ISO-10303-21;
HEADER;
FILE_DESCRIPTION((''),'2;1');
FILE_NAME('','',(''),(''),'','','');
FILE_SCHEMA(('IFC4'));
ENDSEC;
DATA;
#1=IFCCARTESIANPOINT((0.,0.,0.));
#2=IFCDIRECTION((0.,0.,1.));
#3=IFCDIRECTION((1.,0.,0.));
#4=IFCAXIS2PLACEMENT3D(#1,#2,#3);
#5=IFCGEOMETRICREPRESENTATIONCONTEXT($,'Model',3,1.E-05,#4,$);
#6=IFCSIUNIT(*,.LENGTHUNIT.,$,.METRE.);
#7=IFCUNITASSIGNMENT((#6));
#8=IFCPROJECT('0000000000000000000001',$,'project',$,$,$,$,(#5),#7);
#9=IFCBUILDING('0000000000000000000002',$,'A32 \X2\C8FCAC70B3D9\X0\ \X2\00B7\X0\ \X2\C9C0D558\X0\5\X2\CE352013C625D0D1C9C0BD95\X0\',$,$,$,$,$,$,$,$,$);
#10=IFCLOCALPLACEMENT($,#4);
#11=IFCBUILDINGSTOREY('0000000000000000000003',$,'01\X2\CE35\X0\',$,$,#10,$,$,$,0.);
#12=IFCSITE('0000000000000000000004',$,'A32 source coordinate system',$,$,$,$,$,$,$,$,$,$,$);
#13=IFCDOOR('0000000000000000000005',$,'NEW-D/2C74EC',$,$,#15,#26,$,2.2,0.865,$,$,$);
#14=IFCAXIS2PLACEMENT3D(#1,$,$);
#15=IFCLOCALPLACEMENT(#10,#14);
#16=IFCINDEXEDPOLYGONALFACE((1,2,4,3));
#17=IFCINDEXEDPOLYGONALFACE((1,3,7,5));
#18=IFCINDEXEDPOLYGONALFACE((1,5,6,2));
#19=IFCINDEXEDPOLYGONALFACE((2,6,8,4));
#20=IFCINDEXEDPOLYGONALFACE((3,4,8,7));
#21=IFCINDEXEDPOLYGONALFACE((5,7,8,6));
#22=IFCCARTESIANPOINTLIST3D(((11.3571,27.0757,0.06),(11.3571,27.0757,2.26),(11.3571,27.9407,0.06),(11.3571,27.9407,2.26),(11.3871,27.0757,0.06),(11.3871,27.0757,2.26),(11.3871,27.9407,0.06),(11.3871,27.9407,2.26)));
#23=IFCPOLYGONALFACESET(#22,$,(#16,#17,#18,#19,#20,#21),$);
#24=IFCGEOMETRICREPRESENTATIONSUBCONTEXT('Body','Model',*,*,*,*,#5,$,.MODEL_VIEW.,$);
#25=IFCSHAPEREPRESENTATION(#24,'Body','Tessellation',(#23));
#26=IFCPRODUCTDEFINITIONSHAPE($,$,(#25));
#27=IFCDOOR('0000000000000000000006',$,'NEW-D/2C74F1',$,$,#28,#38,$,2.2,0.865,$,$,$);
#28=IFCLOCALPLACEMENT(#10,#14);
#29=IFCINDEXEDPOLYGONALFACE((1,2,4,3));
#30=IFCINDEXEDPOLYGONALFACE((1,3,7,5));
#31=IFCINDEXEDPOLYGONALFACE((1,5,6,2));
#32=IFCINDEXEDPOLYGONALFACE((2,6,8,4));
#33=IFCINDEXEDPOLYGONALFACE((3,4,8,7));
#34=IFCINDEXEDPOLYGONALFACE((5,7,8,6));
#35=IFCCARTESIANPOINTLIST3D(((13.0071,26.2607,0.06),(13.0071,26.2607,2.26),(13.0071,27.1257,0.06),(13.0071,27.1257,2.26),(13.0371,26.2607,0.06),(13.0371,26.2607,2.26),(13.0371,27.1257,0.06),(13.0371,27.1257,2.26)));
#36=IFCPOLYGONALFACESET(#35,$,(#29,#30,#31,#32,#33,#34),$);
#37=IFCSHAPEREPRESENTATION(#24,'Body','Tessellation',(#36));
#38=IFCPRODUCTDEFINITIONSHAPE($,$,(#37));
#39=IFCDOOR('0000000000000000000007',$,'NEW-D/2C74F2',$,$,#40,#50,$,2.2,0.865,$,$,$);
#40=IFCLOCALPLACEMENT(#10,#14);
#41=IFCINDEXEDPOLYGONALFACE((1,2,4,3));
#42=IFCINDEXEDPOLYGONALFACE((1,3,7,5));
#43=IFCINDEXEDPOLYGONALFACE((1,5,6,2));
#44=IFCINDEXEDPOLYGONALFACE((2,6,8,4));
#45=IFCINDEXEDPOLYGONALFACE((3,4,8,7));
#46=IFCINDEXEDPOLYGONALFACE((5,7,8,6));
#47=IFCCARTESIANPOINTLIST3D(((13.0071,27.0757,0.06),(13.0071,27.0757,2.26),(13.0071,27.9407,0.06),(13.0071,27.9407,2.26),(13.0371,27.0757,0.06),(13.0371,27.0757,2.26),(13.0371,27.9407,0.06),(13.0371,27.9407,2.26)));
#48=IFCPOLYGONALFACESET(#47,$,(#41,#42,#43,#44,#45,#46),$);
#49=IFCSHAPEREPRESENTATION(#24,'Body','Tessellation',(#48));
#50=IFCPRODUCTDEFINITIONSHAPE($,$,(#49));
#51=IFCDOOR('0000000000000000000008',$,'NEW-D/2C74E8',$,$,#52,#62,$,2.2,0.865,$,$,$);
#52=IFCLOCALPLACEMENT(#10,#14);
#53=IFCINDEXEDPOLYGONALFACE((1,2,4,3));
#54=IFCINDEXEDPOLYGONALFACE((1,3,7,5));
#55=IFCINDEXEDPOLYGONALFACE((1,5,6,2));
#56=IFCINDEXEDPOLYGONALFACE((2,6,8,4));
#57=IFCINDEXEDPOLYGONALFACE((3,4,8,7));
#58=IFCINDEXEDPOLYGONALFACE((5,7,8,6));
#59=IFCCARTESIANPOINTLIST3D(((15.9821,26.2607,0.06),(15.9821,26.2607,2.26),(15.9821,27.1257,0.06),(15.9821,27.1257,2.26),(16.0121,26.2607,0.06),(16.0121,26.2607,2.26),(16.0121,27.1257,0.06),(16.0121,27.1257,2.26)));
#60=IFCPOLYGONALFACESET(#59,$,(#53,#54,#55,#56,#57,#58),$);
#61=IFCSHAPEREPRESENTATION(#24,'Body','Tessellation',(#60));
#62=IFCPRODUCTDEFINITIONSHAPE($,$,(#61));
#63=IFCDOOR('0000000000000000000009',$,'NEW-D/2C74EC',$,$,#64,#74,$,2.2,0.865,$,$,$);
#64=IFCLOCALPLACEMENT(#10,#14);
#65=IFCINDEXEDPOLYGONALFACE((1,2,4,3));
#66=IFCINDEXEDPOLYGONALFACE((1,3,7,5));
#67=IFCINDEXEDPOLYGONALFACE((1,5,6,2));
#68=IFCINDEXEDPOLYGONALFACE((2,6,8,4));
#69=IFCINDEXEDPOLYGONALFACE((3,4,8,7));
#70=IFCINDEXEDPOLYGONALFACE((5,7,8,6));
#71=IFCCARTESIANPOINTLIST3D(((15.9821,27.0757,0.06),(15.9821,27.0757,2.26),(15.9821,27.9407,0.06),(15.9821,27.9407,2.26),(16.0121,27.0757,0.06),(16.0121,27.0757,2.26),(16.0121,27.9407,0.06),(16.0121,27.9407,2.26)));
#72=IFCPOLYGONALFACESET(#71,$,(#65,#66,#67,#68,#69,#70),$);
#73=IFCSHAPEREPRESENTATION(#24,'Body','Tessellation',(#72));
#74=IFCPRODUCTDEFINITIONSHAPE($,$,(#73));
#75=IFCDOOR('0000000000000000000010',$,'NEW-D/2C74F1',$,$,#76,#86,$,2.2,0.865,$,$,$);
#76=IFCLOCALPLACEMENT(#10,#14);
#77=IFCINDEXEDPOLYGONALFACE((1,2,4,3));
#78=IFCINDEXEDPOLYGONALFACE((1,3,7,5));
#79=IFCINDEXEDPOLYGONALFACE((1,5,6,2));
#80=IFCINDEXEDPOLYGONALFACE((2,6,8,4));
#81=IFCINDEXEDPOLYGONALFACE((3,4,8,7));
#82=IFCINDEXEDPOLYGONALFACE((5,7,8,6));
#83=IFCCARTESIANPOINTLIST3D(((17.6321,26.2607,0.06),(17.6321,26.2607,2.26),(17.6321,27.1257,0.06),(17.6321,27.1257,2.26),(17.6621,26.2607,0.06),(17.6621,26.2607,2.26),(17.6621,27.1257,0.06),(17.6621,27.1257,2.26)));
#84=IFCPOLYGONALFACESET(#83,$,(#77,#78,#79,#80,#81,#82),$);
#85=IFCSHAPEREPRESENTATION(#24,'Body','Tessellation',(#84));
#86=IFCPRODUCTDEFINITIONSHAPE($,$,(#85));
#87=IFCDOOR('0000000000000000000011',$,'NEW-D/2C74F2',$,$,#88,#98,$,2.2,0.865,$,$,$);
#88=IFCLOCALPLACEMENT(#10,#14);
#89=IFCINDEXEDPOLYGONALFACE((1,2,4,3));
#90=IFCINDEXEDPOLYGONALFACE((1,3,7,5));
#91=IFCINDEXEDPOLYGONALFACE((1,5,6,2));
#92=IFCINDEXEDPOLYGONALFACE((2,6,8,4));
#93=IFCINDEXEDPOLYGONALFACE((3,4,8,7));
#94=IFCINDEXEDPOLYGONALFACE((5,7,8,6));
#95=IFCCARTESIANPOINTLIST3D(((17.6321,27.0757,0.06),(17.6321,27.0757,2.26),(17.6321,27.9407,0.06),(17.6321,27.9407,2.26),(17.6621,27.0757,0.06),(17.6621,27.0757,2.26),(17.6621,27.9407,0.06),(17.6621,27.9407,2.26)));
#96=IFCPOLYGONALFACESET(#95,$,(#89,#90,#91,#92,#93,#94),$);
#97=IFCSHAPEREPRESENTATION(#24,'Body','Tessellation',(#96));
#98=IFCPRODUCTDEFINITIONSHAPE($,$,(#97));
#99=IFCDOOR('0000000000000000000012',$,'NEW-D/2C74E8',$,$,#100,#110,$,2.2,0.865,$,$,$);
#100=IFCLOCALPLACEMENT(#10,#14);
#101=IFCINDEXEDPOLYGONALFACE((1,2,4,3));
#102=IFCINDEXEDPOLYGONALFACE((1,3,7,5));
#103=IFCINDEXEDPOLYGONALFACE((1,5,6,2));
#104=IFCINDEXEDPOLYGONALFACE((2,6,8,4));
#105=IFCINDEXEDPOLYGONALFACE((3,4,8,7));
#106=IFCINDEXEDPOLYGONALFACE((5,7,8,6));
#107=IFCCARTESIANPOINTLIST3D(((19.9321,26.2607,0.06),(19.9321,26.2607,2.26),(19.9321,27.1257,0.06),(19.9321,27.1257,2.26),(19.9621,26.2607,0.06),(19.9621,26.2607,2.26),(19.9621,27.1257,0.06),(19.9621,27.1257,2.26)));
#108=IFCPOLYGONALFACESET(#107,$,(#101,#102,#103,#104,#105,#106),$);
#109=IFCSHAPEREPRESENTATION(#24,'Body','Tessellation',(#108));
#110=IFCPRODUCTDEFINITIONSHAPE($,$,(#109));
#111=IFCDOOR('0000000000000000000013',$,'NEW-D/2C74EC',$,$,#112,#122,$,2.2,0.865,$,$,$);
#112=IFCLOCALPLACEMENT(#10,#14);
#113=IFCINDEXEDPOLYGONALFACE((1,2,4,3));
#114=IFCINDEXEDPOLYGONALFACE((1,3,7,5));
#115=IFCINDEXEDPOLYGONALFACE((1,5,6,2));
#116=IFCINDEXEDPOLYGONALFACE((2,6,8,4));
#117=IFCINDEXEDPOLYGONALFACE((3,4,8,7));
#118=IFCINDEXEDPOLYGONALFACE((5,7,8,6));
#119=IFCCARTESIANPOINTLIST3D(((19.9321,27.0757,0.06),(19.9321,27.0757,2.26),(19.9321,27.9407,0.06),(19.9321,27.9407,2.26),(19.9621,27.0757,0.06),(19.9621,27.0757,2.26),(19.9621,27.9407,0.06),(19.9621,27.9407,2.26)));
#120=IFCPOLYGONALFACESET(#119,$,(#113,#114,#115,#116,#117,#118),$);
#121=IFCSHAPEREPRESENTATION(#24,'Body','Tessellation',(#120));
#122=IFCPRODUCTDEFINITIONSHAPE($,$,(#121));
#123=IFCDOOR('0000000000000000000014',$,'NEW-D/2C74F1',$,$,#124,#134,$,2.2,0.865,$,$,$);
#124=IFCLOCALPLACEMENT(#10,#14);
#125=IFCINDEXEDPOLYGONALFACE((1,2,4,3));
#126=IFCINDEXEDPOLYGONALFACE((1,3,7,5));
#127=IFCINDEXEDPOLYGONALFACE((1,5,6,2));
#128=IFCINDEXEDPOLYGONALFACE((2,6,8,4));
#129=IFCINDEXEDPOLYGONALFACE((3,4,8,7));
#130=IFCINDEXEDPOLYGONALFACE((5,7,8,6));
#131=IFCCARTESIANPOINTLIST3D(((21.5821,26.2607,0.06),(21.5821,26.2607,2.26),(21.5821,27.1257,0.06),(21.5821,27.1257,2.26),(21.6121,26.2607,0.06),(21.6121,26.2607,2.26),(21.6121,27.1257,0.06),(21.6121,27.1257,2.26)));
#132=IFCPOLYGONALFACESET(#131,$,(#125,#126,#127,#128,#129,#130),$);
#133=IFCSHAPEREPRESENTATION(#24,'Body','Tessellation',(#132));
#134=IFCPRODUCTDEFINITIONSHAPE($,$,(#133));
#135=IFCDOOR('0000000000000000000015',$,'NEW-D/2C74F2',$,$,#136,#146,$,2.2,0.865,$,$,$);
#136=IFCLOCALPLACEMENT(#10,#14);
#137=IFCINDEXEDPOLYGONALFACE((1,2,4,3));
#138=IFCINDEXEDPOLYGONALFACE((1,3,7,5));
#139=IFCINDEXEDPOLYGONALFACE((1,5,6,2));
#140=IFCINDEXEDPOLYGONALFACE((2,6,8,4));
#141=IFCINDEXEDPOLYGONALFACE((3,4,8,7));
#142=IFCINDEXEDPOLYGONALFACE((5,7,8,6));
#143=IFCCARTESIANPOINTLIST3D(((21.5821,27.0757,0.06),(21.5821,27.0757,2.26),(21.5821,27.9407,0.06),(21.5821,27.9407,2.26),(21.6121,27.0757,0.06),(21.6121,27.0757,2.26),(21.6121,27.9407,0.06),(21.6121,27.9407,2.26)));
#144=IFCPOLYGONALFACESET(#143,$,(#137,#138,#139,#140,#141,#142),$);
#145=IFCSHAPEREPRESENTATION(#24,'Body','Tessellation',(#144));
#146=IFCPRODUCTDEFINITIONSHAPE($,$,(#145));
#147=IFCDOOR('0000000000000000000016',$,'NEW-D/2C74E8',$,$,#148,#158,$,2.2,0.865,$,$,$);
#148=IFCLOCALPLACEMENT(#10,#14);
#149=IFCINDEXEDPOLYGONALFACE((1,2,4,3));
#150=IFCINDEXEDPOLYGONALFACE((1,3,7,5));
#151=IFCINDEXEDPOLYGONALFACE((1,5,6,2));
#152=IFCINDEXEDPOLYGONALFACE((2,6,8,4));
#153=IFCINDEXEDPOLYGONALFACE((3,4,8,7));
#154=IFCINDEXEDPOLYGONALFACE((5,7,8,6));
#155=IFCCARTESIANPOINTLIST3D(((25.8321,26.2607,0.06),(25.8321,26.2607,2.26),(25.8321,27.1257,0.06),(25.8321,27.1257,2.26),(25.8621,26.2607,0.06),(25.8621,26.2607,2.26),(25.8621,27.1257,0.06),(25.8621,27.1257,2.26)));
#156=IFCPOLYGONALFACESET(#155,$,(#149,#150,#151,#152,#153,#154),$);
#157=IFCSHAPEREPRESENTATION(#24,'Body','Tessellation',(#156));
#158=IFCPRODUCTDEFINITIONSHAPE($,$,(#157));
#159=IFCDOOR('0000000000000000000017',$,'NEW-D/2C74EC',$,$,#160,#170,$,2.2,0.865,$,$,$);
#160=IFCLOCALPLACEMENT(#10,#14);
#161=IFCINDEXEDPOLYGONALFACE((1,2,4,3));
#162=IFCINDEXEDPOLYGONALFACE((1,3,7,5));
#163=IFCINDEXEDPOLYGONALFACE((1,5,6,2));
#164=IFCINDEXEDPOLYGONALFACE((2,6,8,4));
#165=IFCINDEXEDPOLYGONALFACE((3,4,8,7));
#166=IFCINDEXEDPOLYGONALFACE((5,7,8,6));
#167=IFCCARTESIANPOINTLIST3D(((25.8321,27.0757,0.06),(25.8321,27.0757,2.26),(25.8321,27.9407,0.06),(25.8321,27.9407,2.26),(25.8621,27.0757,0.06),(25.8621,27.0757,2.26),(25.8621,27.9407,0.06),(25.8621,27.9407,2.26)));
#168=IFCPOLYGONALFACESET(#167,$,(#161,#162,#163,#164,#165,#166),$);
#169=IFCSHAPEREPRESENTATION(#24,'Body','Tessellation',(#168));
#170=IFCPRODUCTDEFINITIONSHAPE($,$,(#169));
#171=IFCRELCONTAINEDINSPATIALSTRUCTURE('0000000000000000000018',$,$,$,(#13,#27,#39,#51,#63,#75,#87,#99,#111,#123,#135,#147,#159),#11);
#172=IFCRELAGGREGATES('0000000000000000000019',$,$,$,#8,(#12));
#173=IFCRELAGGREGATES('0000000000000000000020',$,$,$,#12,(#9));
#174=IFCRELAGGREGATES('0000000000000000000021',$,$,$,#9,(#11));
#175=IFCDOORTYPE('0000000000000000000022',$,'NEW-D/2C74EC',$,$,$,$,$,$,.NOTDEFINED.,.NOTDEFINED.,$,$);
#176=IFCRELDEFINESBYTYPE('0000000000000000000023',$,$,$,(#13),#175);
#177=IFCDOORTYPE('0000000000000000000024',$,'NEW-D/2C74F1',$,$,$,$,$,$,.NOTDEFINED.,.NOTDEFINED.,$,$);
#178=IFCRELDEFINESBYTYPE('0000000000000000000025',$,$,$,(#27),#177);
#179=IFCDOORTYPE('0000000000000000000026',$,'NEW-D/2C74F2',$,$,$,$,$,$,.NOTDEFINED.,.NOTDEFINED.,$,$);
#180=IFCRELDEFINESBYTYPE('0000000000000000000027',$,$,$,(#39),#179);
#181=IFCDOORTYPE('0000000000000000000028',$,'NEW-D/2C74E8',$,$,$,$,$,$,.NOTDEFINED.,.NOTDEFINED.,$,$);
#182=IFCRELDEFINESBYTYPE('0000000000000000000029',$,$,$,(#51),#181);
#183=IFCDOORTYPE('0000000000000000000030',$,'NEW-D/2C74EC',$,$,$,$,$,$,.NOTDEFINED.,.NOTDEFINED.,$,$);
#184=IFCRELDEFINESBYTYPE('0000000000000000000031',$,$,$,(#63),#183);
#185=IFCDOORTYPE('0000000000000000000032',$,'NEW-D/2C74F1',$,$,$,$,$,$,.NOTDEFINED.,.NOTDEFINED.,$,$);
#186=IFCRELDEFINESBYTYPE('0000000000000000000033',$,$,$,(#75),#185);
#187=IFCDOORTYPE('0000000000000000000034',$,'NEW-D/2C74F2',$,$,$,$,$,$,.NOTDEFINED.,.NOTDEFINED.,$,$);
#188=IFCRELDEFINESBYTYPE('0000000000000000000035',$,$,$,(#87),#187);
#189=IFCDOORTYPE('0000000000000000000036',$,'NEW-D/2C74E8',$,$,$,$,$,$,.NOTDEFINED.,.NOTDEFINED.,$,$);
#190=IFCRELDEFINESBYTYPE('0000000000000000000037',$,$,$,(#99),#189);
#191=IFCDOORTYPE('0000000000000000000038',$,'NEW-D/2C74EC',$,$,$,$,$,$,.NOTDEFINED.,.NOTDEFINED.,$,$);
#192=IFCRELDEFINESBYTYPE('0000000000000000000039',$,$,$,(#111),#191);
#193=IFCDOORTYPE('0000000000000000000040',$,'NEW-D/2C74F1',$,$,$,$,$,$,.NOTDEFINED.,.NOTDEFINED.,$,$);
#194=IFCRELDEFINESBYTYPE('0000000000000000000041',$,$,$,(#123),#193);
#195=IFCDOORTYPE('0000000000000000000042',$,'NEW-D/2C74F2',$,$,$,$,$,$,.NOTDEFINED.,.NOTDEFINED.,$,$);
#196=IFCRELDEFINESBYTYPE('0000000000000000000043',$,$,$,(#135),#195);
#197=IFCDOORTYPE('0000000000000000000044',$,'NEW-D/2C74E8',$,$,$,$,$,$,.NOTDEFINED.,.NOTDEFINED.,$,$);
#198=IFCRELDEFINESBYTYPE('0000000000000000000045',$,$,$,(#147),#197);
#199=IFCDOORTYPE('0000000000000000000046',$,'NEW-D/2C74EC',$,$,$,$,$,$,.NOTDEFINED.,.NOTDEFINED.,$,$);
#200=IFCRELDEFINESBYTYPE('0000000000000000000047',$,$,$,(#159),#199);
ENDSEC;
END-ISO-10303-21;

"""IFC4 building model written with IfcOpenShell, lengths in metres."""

from ifc_helpers import new_model, si_unit, frame, origin, origin_with_axes, place, context, subcontext, project, spatial, polyline, outline, extrude, source, transform, mapped, type_object, type_shapes, element, save


model = new_model("IFC4")

# Units and contexts
model_context = context("Model", 3, precision=1e-05, world=origin_with_axes())
body_context = subcontext(model_context, "Body", "Model", "MODEL_VIEW")
ifc_project = project(units=[si_unit("LENGTHUNIT", "METRE")], contexts=[model_context])

# Site, building, storey
site = spatial("IfcSite", under=ifc_project, Name="A32 source coordinate system")
building = spatial("IfcBuilding", under=site, Name="A32 주거동 · 지하5층–옥탑지붕")
storey_placement = place(None, origin_with_axes())
storey = spatial("IfcBuildingStorey", under=building, at=storey_placement, Name="01층", Elevation=0.0)

# Doors
door_type_1 = type_object("IfcDoorType", Name="NEW-D/2C74EC", OperationType="NOTDEFINED", PredefinedType="NOTDEFINED")
shared_shape_1 = source(origin(), body_context, "Body", "SweptSolid", [
    extrude(outline(polyline([(11.3571, 27.9407), (11.3871, 27.9407), (11.3871, 27.0757), (11.3571, 27.0757), (11.3571, 27.9407)])), frame((0.0, 0.0, 0.06)), (0.0, 0.0, 1.0), 2.2),
])
type_shapes(door_type_1, [shared_shape_1])
door_1_placement = place(storey_placement, origin_with_axes())
element("IfcDoor", 1, at=door_1_placement, inside=storey, type_object=door_type_1, Name="NEW-D/2C74EC", OverallHeight=2.2, OverallWidth=0.865, context=body_context, shape_type="MappedRepresentation", body=[
    mapped(shared_shape_1, transform((0.0, 0.0, 0.0), scale=1.0)),
])
door_type_2 = type_object("IfcDoorType", Name="NEW-D/2C74F1", OperationType="NOTDEFINED", PredefinedType="NOTDEFINED")
shared_shape_2 = source(origin(), body_context, "Body", "SweptSolid", [
    extrude(outline(polyline([(13.0371, 26.2607), (13.0071, 26.2607), (13.0071, 27.1257), (13.0371, 27.1257), (13.0371, 26.2607)])), frame((0.0, 0.0, 0.06)), (0.0, 0.0, 1.0), 2.2),
])
type_shapes(door_type_2, [shared_shape_2])
door_2_placement = place(storey_placement, origin_with_axes())
element("IfcDoor", 2, at=door_2_placement, inside=storey, type_object=door_type_2, Name="NEW-D/2C74F1", OverallHeight=2.2, OverallWidth=0.865, context=body_context, shape_type="MappedRepresentation", body=[
    mapped(shared_shape_2, transform((0.0, 0.0, 0.0), scale=1.0)),
])
door_type_3 = type_object("IfcDoorType", Name="NEW-D/2C74F2", OperationType="NOTDEFINED", PredefinedType="NOTDEFINED")
shared_shape_3 = source(origin(), body_context, "Body", "SweptSolid", [
    extrude(outline(polyline([(13.0071, 27.0757), (13.0071, 27.9407), (13.0371, 27.9407), (13.0371, 27.0757), (13.0071, 27.0757)])), frame((0.0, 0.0, 0.06)), (0.0, 0.0, 1.0), 2.2),
])
type_shapes(door_type_3, [shared_shape_3])
door_3_placement = place(storey_placement, origin_with_axes())
element("IfcDoor", 3, at=door_3_placement, inside=storey, type_object=door_type_3, Name="NEW-D/2C74F2", OverallHeight=2.2, OverallWidth=0.865, context=body_context, shape_type="MappedRepresentation", body=[
    mapped(shared_shape_3, transform((0.0, 0.0, 0.0), scale=1.0)),
])
door_type_4 = type_object("IfcDoorType", Name="NEW-D/2C74E8", OperationType="NOTDEFINED", PredefinedType="NOTDEFINED")
shared_shape_4 = source(origin(), body_context, "Body", "SweptSolid", [
    extrude(outline(polyline([(16.0121, 27.1257), (16.0121, 26.2607), (15.9821, 26.2607), (15.9821, 27.1257), (16.0121, 27.1257)])), frame((0.0, 0.0, 0.06)), (0.0, 0.0, 1.0), 2.2),
])
type_shapes(door_type_4, [shared_shape_4])
door_4_placement = place(storey_placement, origin_with_axes())
element("IfcDoor", 4, at=door_4_placement, inside=storey, type_object=door_type_4, Name="NEW-D/2C74E8", OverallHeight=2.2, OverallWidth=0.865, context=body_context, shape_type="MappedRepresentation", body=[
    mapped(shared_shape_4, transform((0.0, 0.0, 0.0), scale=1.0)),
])
door_type_5 = type_object("IfcDoorType", Name="NEW-D/2C74EC", OperationType="NOTDEFINED", PredefinedType="NOTDEFINED")
shared_shape_5 = source(origin(), body_context, "Body", "SweptSolid", [
    extrude(outline(polyline([(15.9821, 27.9407), (16.0121, 27.9407), (16.0121, 27.0757), (15.9821, 27.0757), (15.9821, 27.9407)])), frame((0.0, 0.0, 0.06)), (0.0, 0.0, 1.0), 2.2),
])
type_shapes(door_type_5, [shared_shape_5])
door_5_placement = place(storey_placement, origin_with_axes())
element("IfcDoor", 5, at=door_5_placement, inside=storey, type_object=door_type_5, Name="NEW-D/2C74EC", OverallHeight=2.2, OverallWidth=0.865, context=body_context, shape_type="MappedRepresentation", body=[
    mapped(shared_shape_5, transform((0.0, 0.0, 0.0), scale=1.0)),
])
door_type_6 = type_object("IfcDoorType", Name="NEW-D/2C74F1", OperationType="NOTDEFINED", PredefinedType="NOTDEFINED")
shared_shape_6 = source(origin(), body_context, "Body", "SweptSolid", [
    extrude(outline(polyline([(17.6621, 26.2607), (17.6321, 26.2607), (17.6321, 27.1257), (17.6621, 27.1257), (17.6621, 26.2607)])), frame((0.0, 0.0, 0.06)), (0.0, 0.0, 1.0), 2.2),
])
type_shapes(door_type_6, [shared_shape_6])
door_6_placement = place(storey_placement, origin_with_axes())
element("IfcDoor", 6, at=door_6_placement, inside=storey, type_object=door_type_6, Name="NEW-D/2C74F1", OverallHeight=2.2, OverallWidth=0.865, context=body_context, shape_type="MappedRepresentation", body=[
    mapped(shared_shape_6, transform((0.0, 0.0, 0.0), scale=1.0)),
])
door_type_7 = type_object("IfcDoorType", Name="NEW-D/2C74F2", OperationType="NOTDEFINED", PredefinedType="NOTDEFINED")
shared_shape_7 = source(origin(), body_context, "Body", "SweptSolid", [
    extrude(outline(polyline([(17.6321, 27.0757), (17.6321, 27.9407), (17.6621, 27.9407), (17.6621, 27.0757), (17.6321, 27.0757)])), frame((0.0, 0.0, 0.06)), (0.0, 0.0, 1.0), 2.2),
])
type_shapes(door_type_7, [shared_shape_7])
door_7_placement = place(storey_placement, origin_with_axes())
element("IfcDoor", 7, at=door_7_placement, inside=storey, type_object=door_type_7, Name="NEW-D/2C74F2", OverallHeight=2.2, OverallWidth=0.865, context=body_context, shape_type="MappedRepresentation", body=[
    mapped(shared_shape_7, transform((0.0, 0.0, 0.0), scale=1.0)),
])
door_type_8 = type_object("IfcDoorType", Name="NEW-D/2C74E8", OperationType="NOTDEFINED", PredefinedType="NOTDEFINED")
shared_shape_8 = source(origin(), body_context, "Body", "SweptSolid", [
    extrude(outline(polyline([(19.9621, 27.1257), (19.9621, 26.2607), (19.9321, 26.2607), (19.9321, 27.1257), (19.9621, 27.1257)])), frame((0.0, 0.0, 0.06)), (0.0, 0.0, 1.0), 2.2),
])
type_shapes(door_type_8, [shared_shape_8])
door_8_placement = place(storey_placement, origin_with_axes())
element("IfcDoor", 8, at=door_8_placement, inside=storey, type_object=door_type_8, Name="NEW-D/2C74E8", OverallHeight=2.2, OverallWidth=0.865, context=body_context, shape_type="MappedRepresentation", body=[
    mapped(shared_shape_8, transform((0.0, 0.0, 0.0), scale=1.0)),
])
door_type_9 = type_object("IfcDoorType", Name="NEW-D/2C74EC", OperationType="NOTDEFINED", PredefinedType="NOTDEFINED")
shared_shape_9 = source(origin(), body_context, "Body", "SweptSolid", [
    extrude(outline(polyline([(19.9321, 27.9407), (19.9621, 27.9407), (19.9621, 27.0757), (19.9321, 27.0757), (19.9321, 27.9407)])), frame((0.0, 0.0, 0.06)), (0.0, 0.0, 1.0), 2.2),
])
type_shapes(door_type_9, [shared_shape_9])
door_9_placement = place(storey_placement, origin_with_axes())
element("IfcDoor", 9, at=door_9_placement, inside=storey, type_object=door_type_9, Name="NEW-D/2C74EC", OverallHeight=2.2, OverallWidth=0.865, context=body_context, shape_type="MappedRepresentation", body=[
    mapped(shared_shape_9, transform((0.0, 0.0, 0.0), scale=1.0)),
])
door_type_10 = type_object("IfcDoorType", Name="NEW-D/2C74F1", OperationType="NOTDEFINED", PredefinedType="NOTDEFINED")
shared_shape_10 = source(origin(), body_context, "Body", "SweptSolid", [
    extrude(outline(polyline([(21.6121, 26.2607), (21.5821, 26.2607), (21.5821, 27.1257), (21.6121, 27.1257), (21.6121, 26.2607)])), frame((0.0, 0.0, 0.06)), (0.0, 0.0, 1.0), 2.2),
])
type_shapes(door_type_10, [shared_shape_10])
door_10_placement = place(storey_placement, origin_with_axes())
element("IfcDoor", 10, at=door_10_placement, inside=storey, type_object=door_type_10, Name="NEW-D/2C74F1", OverallHeight=2.2, OverallWidth=0.865, context=body_context, shape_type="MappedRepresentation", body=[
    mapped(shared_shape_10, transform((0.0, 0.0, 0.0), scale=1.0)),
])
door_type_11 = type_object("IfcDoorType", Name="NEW-D/2C74F2", OperationType="NOTDEFINED", PredefinedType="NOTDEFINED")
shared_shape_11 = source(origin(), body_context, "Body", "SweptSolid", [
    extrude(outline(polyline([(21.5821, 27.0757), (21.5821, 27.9407), (21.6121, 27.9407), (21.6121, 27.0757), (21.5821, 27.0757)])), frame((0.0, 0.0, 0.06)), (0.0, 0.0, 1.0), 2.2),
])
type_shapes(door_type_11, [shared_shape_11])
door_11_placement = place(storey_placement, origin_with_axes())
element("IfcDoor", 11, at=door_11_placement, inside=storey, type_object=door_type_11, Name="NEW-D/2C74F2", OverallHeight=2.2, OverallWidth=0.865, context=body_context, shape_type="MappedRepresentation", body=[
    mapped(shared_shape_11, transform((0.0, 0.0, 0.0), scale=1.0)),
])
door_type_12 = type_object("IfcDoorType", Name="NEW-D/2C74E8", OperationType="NOTDEFINED", PredefinedType="NOTDEFINED")
shared_shape_12 = source(origin(), body_context, "Body", "SweptSolid", [
    extrude(outline(polyline([(25.8621, 27.1257), (25.8621, 26.2607), (25.8321, 26.2607), (25.8321, 27.1257), (25.8621, 27.1257)])), frame((0.0, 0.0, 0.06)), (0.0, 0.0, 1.0), 2.2),
])
type_shapes(door_type_12, [shared_shape_12])
door_12_placement = place(storey_placement, origin_with_axes())
element("IfcDoor", 12, at=door_12_placement, inside=storey, type_object=door_type_12, Name="NEW-D/2C74E8", OverallHeight=2.2, OverallWidth=0.865, context=body_context, shape_type="MappedRepresentation", body=[
    mapped(shared_shape_12, transform((0.0, 0.0, 0.0), scale=1.0)),
])
door_type_13 = type_object("IfcDoorType", Name="NEW-D/2C74EC", OperationType="NOTDEFINED", PredefinedType="NOTDEFINED")
shared_shape_13 = source(origin(), body_context, "Body", "SweptSolid", [
    extrude(outline(polyline([(25.8321, 27.9407), (25.8621, 27.9407), (25.8621, 27.0757), (25.8321, 27.0757), (25.8321, 27.9407)])), frame((0.0, 0.0, 0.06)), (0.0, 0.0, 1.0), 2.2),
])
type_shapes(door_type_13, [shared_shape_13])
door_13_placement = place(storey_placement, origin_with_axes())
element("IfcDoor", 13, at=door_13_placement, inside=storey, type_object=door_type_13, Name="NEW-D/2C74EC", OverallHeight=2.2, OverallWidth=0.865, context=body_context, shape_type="MappedRepresentation", body=[
    mapped(shared_shape_13, transform((0.0, 0.0, 0.0), scale=1.0)),
])

save(model, "model.ifc")
